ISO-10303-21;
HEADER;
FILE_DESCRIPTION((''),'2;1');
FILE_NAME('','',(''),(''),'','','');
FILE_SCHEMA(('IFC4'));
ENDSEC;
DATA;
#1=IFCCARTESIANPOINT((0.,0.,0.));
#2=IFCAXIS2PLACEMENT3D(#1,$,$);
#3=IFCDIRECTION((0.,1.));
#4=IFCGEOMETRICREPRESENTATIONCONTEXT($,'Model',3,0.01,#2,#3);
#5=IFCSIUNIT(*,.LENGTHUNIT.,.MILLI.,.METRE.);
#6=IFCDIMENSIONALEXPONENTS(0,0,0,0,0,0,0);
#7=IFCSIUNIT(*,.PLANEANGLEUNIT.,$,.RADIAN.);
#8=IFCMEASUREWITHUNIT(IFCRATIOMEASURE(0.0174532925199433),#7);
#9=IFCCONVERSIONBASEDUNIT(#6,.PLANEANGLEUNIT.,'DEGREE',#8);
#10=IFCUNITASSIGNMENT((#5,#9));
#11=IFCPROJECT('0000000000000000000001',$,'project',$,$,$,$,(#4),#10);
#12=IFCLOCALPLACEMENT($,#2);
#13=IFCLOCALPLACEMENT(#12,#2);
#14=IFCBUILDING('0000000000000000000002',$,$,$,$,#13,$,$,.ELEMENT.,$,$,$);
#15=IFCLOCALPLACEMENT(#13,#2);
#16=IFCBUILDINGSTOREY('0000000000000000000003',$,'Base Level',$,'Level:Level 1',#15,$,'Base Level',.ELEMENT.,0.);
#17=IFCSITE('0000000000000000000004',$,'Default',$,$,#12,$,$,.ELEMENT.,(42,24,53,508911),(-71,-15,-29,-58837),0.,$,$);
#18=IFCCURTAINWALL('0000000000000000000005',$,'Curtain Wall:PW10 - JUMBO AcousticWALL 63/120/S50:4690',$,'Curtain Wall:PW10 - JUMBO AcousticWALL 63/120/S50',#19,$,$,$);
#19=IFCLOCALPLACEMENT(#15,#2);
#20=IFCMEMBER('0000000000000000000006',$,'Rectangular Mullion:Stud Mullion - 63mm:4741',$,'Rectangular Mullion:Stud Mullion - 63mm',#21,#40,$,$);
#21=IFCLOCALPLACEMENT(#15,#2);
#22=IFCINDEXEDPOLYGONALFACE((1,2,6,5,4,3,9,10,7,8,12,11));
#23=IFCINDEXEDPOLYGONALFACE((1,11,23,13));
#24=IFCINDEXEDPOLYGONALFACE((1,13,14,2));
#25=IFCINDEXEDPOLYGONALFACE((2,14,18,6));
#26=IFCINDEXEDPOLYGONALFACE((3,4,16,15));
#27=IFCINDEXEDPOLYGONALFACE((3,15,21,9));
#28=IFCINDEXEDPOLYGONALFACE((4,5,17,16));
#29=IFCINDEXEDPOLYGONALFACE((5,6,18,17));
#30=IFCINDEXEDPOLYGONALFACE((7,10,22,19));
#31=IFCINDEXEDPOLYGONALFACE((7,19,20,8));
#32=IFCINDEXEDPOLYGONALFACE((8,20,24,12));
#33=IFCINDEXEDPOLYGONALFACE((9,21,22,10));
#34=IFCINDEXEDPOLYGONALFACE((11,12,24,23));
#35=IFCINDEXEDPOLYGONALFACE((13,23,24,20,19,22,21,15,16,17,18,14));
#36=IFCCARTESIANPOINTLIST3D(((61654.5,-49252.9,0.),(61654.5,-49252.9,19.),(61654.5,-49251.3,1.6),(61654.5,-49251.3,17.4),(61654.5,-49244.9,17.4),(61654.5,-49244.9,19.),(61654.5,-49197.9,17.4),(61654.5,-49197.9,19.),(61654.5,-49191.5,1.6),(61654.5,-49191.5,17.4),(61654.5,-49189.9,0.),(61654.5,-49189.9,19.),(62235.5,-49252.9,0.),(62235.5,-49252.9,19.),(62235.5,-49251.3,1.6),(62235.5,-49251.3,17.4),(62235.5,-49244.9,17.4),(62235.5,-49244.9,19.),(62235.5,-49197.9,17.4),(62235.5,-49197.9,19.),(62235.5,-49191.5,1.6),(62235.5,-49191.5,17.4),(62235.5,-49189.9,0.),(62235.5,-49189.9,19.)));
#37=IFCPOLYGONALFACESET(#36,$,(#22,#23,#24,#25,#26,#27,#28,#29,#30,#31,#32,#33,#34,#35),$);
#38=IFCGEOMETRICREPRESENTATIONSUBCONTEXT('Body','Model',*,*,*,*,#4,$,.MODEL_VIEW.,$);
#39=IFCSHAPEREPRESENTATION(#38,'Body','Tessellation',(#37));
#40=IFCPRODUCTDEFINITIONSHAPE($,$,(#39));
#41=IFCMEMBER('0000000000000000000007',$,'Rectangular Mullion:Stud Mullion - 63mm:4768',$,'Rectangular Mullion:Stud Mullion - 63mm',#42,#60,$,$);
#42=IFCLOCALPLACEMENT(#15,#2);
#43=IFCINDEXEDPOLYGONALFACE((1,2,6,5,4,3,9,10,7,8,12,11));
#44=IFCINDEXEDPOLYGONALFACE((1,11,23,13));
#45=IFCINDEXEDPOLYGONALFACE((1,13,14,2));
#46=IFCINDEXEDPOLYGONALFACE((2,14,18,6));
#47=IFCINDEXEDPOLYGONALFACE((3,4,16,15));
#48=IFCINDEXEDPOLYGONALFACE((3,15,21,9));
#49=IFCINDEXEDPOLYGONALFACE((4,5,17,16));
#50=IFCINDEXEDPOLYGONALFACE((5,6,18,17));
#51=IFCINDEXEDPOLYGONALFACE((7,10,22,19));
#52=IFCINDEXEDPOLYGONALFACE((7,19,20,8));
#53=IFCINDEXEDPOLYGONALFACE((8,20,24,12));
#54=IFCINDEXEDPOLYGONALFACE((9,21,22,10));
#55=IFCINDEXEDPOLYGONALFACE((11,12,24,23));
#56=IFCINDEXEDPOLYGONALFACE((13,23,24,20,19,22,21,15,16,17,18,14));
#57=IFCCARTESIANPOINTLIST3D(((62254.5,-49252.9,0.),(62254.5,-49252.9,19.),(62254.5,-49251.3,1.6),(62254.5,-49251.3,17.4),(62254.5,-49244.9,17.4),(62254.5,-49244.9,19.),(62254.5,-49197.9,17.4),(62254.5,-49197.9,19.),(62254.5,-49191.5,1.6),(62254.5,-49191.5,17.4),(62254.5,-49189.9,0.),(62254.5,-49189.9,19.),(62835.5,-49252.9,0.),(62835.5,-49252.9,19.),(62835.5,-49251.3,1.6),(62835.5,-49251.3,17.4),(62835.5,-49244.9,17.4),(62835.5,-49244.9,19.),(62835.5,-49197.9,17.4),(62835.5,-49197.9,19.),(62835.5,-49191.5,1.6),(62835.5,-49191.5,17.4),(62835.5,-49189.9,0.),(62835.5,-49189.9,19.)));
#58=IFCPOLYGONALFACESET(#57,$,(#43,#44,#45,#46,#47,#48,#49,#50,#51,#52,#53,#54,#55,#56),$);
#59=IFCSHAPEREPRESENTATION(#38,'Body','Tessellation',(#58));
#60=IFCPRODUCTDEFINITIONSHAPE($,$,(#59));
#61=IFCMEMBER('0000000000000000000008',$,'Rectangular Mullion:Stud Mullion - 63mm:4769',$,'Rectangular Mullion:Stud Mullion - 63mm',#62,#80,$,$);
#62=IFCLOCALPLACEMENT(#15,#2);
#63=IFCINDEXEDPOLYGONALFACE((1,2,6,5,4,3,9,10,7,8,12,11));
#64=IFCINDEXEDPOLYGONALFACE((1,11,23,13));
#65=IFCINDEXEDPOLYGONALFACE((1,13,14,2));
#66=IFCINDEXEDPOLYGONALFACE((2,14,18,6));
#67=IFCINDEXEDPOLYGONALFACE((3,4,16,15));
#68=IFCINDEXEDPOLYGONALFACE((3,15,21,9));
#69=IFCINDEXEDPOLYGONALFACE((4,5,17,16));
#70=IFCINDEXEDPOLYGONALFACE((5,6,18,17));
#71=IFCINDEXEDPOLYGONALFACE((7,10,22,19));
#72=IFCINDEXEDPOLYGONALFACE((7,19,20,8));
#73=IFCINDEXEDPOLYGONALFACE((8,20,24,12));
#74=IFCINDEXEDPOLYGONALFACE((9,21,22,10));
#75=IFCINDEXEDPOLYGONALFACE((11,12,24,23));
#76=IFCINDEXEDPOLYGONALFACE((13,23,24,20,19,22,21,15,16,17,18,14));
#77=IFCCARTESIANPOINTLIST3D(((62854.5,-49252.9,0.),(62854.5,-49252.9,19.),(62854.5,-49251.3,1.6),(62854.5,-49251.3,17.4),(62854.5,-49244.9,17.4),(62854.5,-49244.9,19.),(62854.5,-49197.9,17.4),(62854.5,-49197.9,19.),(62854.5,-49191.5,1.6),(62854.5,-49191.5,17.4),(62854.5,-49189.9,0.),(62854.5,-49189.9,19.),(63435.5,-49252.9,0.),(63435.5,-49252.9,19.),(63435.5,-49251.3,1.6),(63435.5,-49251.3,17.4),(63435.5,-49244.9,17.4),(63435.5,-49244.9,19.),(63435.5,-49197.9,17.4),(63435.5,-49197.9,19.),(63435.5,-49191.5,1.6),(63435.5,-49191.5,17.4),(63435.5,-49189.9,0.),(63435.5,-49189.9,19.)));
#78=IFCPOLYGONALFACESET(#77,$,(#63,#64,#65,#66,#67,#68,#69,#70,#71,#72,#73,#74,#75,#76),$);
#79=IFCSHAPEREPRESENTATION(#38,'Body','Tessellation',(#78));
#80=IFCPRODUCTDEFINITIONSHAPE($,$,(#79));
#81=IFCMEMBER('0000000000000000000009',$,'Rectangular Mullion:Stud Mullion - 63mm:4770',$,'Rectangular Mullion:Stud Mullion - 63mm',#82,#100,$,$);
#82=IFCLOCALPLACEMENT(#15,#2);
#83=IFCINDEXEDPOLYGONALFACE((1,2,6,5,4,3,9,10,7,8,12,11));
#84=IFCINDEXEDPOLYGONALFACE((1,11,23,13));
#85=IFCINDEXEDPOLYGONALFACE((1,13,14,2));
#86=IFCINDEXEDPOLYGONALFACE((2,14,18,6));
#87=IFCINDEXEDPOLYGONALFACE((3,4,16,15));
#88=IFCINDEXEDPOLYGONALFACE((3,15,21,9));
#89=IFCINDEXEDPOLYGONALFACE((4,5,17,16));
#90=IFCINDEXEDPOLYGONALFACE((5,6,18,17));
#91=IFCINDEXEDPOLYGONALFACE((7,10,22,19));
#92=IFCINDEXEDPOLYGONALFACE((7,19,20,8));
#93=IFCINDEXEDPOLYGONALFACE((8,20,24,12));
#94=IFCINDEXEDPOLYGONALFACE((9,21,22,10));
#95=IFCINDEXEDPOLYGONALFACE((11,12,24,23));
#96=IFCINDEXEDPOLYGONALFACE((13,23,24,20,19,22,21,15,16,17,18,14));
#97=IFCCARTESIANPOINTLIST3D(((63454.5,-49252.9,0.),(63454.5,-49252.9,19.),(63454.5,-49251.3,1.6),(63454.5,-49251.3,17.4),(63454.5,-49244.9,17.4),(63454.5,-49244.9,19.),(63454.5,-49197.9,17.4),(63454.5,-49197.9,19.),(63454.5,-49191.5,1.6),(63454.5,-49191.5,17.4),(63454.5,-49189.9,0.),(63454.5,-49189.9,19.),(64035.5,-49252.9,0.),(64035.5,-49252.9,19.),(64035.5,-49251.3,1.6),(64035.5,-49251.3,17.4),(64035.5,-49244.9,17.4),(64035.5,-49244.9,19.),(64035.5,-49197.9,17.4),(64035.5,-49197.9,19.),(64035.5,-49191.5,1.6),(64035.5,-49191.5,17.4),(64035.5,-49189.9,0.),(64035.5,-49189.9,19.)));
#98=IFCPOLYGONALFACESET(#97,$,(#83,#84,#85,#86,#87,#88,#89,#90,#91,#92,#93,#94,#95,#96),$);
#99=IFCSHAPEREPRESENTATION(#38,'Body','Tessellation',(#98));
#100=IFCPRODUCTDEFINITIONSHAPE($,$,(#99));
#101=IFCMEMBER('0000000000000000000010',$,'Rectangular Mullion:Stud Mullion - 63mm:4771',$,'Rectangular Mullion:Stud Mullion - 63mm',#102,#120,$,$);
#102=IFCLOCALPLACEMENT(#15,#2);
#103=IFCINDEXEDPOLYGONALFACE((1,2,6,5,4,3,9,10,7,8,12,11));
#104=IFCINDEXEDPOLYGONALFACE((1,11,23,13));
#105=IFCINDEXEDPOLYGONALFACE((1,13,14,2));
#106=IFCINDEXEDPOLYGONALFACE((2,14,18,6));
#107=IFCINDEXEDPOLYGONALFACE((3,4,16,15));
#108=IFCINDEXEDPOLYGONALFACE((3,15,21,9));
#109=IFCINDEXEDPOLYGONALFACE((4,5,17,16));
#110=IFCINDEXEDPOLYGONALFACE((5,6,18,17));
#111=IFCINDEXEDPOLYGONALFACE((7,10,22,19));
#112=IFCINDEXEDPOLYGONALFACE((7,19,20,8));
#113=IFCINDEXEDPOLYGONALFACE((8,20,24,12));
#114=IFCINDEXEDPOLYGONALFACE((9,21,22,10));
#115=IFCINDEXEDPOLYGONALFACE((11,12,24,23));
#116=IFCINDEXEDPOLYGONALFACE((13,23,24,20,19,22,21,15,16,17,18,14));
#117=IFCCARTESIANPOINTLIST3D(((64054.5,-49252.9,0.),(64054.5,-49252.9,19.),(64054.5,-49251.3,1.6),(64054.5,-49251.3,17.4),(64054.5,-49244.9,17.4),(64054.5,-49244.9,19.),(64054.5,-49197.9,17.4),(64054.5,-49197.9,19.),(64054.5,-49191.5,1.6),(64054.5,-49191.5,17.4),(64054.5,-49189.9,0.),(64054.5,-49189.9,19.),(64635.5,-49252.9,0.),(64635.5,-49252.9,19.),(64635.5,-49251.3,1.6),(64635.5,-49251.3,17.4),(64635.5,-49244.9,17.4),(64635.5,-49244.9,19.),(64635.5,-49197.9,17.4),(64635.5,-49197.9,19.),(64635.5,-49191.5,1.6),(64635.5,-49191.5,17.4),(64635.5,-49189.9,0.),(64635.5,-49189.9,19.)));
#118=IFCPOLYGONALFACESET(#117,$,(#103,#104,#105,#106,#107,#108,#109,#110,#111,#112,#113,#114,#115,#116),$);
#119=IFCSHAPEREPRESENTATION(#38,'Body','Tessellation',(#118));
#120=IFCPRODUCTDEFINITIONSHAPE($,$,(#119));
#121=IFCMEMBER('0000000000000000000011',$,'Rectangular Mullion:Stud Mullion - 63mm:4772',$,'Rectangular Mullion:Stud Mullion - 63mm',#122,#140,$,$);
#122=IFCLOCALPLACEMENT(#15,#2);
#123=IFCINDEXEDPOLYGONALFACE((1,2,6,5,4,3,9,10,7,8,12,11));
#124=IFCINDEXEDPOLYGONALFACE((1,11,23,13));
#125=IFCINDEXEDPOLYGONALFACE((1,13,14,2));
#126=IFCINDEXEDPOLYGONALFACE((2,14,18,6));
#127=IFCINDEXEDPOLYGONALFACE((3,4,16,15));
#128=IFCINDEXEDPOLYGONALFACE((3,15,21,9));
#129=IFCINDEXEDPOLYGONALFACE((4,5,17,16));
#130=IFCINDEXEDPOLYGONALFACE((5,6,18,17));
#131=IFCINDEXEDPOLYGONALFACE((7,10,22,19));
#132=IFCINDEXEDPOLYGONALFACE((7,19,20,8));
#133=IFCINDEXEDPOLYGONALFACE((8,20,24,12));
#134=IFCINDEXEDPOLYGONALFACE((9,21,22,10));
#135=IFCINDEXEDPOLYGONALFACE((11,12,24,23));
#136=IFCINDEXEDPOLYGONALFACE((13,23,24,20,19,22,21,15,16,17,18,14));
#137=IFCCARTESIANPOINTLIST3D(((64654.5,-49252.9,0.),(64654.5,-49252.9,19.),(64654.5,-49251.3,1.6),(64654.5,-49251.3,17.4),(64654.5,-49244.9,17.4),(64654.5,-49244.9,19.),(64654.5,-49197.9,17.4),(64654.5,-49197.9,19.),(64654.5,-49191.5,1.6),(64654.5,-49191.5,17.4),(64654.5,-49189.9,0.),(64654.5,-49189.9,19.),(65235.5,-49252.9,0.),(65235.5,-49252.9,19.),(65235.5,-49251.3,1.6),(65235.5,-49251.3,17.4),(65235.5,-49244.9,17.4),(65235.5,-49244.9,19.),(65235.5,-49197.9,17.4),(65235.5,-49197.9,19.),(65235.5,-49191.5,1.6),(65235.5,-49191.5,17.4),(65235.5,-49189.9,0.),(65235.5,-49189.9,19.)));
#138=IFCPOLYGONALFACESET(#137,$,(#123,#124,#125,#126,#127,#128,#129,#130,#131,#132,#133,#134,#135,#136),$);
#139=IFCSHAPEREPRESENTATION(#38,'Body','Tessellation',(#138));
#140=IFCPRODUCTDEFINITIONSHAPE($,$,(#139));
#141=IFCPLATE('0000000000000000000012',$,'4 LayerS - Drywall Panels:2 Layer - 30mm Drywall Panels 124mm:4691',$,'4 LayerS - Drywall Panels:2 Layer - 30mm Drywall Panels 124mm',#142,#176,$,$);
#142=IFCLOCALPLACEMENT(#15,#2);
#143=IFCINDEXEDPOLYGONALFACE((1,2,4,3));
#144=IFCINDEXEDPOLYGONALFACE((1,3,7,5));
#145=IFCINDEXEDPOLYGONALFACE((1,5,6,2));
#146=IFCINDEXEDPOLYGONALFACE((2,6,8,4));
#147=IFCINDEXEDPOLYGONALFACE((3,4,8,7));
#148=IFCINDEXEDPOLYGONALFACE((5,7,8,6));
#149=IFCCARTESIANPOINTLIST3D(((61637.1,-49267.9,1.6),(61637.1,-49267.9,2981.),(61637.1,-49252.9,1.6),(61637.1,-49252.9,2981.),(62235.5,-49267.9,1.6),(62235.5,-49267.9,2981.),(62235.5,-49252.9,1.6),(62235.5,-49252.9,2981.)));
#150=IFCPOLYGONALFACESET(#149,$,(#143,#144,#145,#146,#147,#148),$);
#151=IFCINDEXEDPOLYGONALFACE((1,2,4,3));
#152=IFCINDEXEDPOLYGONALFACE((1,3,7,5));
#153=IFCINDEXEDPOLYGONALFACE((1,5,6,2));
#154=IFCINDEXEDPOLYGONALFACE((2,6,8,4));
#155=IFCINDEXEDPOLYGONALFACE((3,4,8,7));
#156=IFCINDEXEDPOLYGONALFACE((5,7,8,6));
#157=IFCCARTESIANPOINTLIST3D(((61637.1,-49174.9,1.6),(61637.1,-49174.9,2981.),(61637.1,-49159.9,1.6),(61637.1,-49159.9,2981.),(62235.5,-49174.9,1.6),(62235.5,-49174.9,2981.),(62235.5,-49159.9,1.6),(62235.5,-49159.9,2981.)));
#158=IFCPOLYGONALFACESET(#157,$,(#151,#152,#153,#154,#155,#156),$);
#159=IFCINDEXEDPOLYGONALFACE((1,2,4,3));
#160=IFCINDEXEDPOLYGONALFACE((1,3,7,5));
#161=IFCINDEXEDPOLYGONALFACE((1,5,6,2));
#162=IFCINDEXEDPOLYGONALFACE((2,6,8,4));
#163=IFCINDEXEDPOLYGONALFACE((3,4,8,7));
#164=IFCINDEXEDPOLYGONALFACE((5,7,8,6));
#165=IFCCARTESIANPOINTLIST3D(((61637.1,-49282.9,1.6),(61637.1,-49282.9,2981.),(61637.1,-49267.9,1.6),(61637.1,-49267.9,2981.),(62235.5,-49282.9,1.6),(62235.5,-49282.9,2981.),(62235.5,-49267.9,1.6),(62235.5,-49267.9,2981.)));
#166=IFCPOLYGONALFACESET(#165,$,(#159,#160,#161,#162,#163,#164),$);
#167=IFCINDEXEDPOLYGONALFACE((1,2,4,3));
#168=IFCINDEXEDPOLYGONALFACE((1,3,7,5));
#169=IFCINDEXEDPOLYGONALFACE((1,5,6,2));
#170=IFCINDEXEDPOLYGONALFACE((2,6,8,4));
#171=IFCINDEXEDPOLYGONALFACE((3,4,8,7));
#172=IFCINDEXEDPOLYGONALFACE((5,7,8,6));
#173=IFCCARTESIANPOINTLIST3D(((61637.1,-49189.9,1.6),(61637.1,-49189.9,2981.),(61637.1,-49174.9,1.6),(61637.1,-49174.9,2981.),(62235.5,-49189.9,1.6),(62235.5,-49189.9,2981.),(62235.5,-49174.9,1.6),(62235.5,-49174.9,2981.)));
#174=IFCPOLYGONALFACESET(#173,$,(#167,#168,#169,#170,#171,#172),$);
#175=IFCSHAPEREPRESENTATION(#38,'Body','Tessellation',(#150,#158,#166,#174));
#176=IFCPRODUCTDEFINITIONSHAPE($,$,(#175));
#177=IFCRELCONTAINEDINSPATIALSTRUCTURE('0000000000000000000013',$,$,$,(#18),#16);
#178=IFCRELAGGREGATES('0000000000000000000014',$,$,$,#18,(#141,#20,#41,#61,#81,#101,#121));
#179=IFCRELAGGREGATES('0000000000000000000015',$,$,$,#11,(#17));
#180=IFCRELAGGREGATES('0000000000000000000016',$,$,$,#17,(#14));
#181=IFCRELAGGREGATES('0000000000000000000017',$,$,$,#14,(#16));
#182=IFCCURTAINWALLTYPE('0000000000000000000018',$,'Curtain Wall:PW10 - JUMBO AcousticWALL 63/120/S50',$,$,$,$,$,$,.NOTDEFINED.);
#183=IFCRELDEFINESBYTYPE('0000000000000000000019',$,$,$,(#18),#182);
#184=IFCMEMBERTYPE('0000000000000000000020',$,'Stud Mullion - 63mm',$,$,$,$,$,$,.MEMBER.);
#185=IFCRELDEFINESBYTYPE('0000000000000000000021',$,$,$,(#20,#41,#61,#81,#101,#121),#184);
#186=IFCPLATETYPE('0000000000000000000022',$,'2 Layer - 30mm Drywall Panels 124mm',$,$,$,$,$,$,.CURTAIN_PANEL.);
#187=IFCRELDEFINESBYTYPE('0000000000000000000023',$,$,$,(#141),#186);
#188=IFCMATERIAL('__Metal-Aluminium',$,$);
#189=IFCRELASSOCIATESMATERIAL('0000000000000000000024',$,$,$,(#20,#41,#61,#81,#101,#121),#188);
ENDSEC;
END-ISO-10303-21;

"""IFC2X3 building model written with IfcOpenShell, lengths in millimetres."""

from ifc_helpers import new_model, entity, si_unit, converted_unit, direction, frame, frame_2d, origin, origin_2d_with_axis, place, context, subcontext, project, spatial, polyline, rectangle, outline, extrude, source, transform, mapped, material, type_object, type_shapes, element, aggregate, save


model = new_model("IFC2X3")

# Units and contexts
model_context = context("Model", 3, precision=0.01, world=origin(), true_north=direction((0.0, 1.0)))
body_context = subcontext(model_context, "Body", "Model", "MODEL_VIEW")
ifc_project = project(units=[si_unit("LENGTHUNIT", "METRE", prefix="MILLI"), converted_unit("PLANEANGLEUNIT", "DEGREE", entity("IfcRatioMeasure", 0.0174532925199433), si_unit("PLANEANGLEUNIT", "RADIAN"), dimensions=[0, 0, 0, 0, 0, 0, 0])], contexts=[model_context])

# Site, building, storey
site_placement = place(None, origin())
site = spatial("IfcSite", under=ifc_project, at=site_placement, Name="Default", CompositionType="ELEMENT", RefLatitude=(42, 24, 53, 508911), RefLongitude=(-71, -15, -29, -58837), RefElevation=0.0)
building_placement = place(site_placement, origin())
building = spatial("IfcBuilding", under=site, at=building_placement, CompositionType="ELEMENT")
storey_placement = place(building_placement, origin())
storey = spatial("IfcBuildingStorey", under=building, at=storey_placement, Name="Base Level", ObjectType="Level:Level 1", LongName="Base Level", CompositionType="ELEMENT", Elevation=0.0)

# Curtain wall, members, plate
curtain_wall_type = type_object("IfcCurtainWallType", Name="Curtain Wall:PW10 - JUMBO AcousticWALL 63/120/S50", PredefinedType="NOTDEFINED")
curtain_wall_placement = place(building_placement, origin())
curtain_wall = element("IfcCurtainWall", 1, at=curtain_wall_placement, inside=storey, type_object=curtain_wall_type, Name="Curtain Wall:PW10 - JUMBO AcousticWALL 63/120/S50:4690", ObjectType="Curtain Wall:PW10 - JUMBO AcousticWALL 63/120/S50")
ifc_material_1 = material(Name="__Metal-Aluminium")
member_type_1 = type_object("IfcMemberType", Name="Stud Mullion - 63mm", PredefinedType="MEMBER")
shared_shape_1 = source(origin(), body_context, "Body", "SweptSolid", [
    extrude(outline(polyline([(23.5, -6.6), (31.5, -6.6), (31.5, 12.4), (-31.5, 12.4), (-31.5, -6.6), (-23.5, -6.6), (-23.5, -5.0), (-29.9, -5.0), (-29.9, 10.8), (29.9, 10.8), (29.9, -5.0), (23.5, -5.0), (23.5, -6.6)])), frame((-12.4, 0.0, -581.0), z_axis=(0.0, 0.0, 1.0), x_axis=(0.0, -1.0, 0.0)), (0.0, 0.0, 1.0), 581.0),
])
type_shapes(member_type_1, [shared_shape_1])
member_1_placement = place(building_placement, frame((61654.5, -49221.4, 0.0), z_axis=(-1.0, 0.0, 0.0), x_axis=(0.0, 0.0, -1.0)))
member_1 = element("IfcMember", 2, at=member_1_placement, type_object=member_type_1, material=ifc_material_1, Name="Rectangular Mullion:Stud Mullion - 63mm:4741", ObjectType="Rectangular Mullion:Stud Mullion - 63mm", context=body_context, shape_type="MappedRepresentation", body=[
    mapped(shared_shape_1, transform((0.0, 0.0, 0.0), scale=1.0)),
])
member_2_placement = place(building_placement, frame((62254.5, -49221.4, 0.0), z_axis=(-1.0, 0.0, 0.0), x_axis=(0.0, 0.0, -1.0)))
member_2 = element("IfcMember", 3, at=member_2_placement, type_object=member_type_1, material=ifc_material_1, Name="Rectangular Mullion:Stud Mullion - 63mm:4768", ObjectType="Rectangular Mullion:Stud Mullion - 63mm", context=body_context, shape_type="MappedRepresentation", body=[
    mapped(shared_shape_1, transform((0.0, 0.0, 0.0), scale=1.0)),
])
member_3_placement = place(building_placement, frame((62854.5, -49221.4, 0.0), z_axis=(-1.0, 0.0, 0.0), x_axis=(0.0, 0.0, -1.0)))
member_3 = element("IfcMember", 4, at=member_3_placement, type_object=member_type_1, material=ifc_material_1, Name="Rectangular Mullion:Stud Mullion - 63mm:4769", ObjectType="Rectangular Mullion:Stud Mullion - 63mm", context=body_context, shape_type="MappedRepresentation", body=[
    mapped(shared_shape_1, transform((0.0, 0.0, 0.0), scale=1.0)),
])
member_4_placement = place(building_placement, frame((63454.5, -49221.4, 0.0), z_axis=(-1.0, 0.0, 0.0), x_axis=(0.0, 0.0, -1.0)))
member_4 = element("IfcMember", 5, at=member_4_placement, type_object=member_type_1, material=ifc_material_1, Name="Rectangular Mullion:Stud Mullion - 63mm:4770", ObjectType="Rectangular Mullion:Stud Mullion - 63mm", context=body_context, shape_type="MappedRepresentation", body=[
    mapped(shared_shape_1, transform((0.0, 0.0, 0.0), scale=1.0)),
])
member_5_placement = place(building_placement, frame((64054.5, -49221.4, 0.0), z_axis=(-1.0, 0.0, 0.0), x_axis=(0.0, 0.0, -1.0)))
member_5 = element("IfcMember", 6, at=member_5_placement, type_object=member_type_1, material=ifc_material_1, Name="Rectangular Mullion:Stud Mullion - 63mm:4771", ObjectType="Rectangular Mullion:Stud Mullion - 63mm", context=body_context, shape_type="MappedRepresentation", body=[
    mapped(shared_shape_1, transform((0.0, 0.0, 0.0), scale=1.0)),
])
member_6_placement = place(building_placement, frame((64654.5, -49221.4, 0.0), z_axis=(-1.0, 0.0, 0.0), x_axis=(0.0, 0.0, -1.0)))
member_6 = element("IfcMember", 7, at=member_6_placement, type_object=member_type_1, material=ifc_material_1, Name="Rectangular Mullion:Stud Mullion - 63mm:4772", ObjectType="Rectangular Mullion:Stud Mullion - 63mm", context=body_context, shape_type="MappedRepresentation", body=[
    mapped(shared_shape_1, transform((0.0, 0.0, 0.0), scale=1.0)),
])
plate_type = type_object("IfcPlateType", Name="2 Layer - 30mm Drywall Panels 124mm", PredefinedType="CURTAIN_PANEL")
shared_shape_2 = source(origin(), body_context, "Body", "SweptSolid", [
    extrude(rectangle(XDim=15.0, YDim=598.4, at=origin_2d_with_axis()), frame((0.0, -39.0, 0.0), z_axis=(0.0, 0.0, 1.0), x_axis=(0.0, 1.0, 0.0)), (0.0, 0.0, 1.0), 2979.4),
    extrude(rectangle(XDim=15.0, YDim=598.4, at=origin_2d_with_axis()), frame((0.0, 54.0, 0.0), z_axis=(0.0, 0.0, 1.0), x_axis=(0.0, 1.0, 0.0)), (0.0, 0.0, 1.0), 2979.4),
    extrude(rectangle(XDim=598.4, YDim=15.0, at=frame_2d((0.0, 0.0), x_axis=(1.0, 0.0))), frame((0.0, -54.0, 0.0), z_axis=(0.0, 0.0, 1.0), x_axis=(-1.0, 0.0, 0.0)), (0.0, 0.0, 1.0), 2979.4),
    extrude(rectangle(XDim=15.0, YDim=598.4, at=frame_2d((0.0, 0.0), x_axis=(1.0, 0.0))), frame((0.0, 39.0, 0.0), z_axis=(0.0, 0.0, 1.0), x_axis=(0.0, 1.0, 0.0)), (0.0, 0.0, 1.0), 2979.4),
])
type_shapes(plate_type, [shared_shape_2])
plate_1_placement = place(curtain_wall_placement, frame((61936.3, -49221.4, 1.6)))
plate_1 = element("IfcPlate", 8, at=plate_1_placement, type_object=plate_type, Name="4 LayerS - Drywall Panels:2 Layer - 30mm Drywall Panels 124mm:4691", ObjectType="4 LayerS - Drywall Panels:2 Layer - 30mm Drywall Panels 124mm", context=body_context, shape_type="MappedRepresentation", body=[
    mapped(shared_shape_2, transform((0.0, 0.0, 0.0), scale=1.0)),
])
aggregate(curtain_wall, [plate_1, member_1, member_2, member_3, member_4, member_5, member_6])

save(model, "model.ifc")
